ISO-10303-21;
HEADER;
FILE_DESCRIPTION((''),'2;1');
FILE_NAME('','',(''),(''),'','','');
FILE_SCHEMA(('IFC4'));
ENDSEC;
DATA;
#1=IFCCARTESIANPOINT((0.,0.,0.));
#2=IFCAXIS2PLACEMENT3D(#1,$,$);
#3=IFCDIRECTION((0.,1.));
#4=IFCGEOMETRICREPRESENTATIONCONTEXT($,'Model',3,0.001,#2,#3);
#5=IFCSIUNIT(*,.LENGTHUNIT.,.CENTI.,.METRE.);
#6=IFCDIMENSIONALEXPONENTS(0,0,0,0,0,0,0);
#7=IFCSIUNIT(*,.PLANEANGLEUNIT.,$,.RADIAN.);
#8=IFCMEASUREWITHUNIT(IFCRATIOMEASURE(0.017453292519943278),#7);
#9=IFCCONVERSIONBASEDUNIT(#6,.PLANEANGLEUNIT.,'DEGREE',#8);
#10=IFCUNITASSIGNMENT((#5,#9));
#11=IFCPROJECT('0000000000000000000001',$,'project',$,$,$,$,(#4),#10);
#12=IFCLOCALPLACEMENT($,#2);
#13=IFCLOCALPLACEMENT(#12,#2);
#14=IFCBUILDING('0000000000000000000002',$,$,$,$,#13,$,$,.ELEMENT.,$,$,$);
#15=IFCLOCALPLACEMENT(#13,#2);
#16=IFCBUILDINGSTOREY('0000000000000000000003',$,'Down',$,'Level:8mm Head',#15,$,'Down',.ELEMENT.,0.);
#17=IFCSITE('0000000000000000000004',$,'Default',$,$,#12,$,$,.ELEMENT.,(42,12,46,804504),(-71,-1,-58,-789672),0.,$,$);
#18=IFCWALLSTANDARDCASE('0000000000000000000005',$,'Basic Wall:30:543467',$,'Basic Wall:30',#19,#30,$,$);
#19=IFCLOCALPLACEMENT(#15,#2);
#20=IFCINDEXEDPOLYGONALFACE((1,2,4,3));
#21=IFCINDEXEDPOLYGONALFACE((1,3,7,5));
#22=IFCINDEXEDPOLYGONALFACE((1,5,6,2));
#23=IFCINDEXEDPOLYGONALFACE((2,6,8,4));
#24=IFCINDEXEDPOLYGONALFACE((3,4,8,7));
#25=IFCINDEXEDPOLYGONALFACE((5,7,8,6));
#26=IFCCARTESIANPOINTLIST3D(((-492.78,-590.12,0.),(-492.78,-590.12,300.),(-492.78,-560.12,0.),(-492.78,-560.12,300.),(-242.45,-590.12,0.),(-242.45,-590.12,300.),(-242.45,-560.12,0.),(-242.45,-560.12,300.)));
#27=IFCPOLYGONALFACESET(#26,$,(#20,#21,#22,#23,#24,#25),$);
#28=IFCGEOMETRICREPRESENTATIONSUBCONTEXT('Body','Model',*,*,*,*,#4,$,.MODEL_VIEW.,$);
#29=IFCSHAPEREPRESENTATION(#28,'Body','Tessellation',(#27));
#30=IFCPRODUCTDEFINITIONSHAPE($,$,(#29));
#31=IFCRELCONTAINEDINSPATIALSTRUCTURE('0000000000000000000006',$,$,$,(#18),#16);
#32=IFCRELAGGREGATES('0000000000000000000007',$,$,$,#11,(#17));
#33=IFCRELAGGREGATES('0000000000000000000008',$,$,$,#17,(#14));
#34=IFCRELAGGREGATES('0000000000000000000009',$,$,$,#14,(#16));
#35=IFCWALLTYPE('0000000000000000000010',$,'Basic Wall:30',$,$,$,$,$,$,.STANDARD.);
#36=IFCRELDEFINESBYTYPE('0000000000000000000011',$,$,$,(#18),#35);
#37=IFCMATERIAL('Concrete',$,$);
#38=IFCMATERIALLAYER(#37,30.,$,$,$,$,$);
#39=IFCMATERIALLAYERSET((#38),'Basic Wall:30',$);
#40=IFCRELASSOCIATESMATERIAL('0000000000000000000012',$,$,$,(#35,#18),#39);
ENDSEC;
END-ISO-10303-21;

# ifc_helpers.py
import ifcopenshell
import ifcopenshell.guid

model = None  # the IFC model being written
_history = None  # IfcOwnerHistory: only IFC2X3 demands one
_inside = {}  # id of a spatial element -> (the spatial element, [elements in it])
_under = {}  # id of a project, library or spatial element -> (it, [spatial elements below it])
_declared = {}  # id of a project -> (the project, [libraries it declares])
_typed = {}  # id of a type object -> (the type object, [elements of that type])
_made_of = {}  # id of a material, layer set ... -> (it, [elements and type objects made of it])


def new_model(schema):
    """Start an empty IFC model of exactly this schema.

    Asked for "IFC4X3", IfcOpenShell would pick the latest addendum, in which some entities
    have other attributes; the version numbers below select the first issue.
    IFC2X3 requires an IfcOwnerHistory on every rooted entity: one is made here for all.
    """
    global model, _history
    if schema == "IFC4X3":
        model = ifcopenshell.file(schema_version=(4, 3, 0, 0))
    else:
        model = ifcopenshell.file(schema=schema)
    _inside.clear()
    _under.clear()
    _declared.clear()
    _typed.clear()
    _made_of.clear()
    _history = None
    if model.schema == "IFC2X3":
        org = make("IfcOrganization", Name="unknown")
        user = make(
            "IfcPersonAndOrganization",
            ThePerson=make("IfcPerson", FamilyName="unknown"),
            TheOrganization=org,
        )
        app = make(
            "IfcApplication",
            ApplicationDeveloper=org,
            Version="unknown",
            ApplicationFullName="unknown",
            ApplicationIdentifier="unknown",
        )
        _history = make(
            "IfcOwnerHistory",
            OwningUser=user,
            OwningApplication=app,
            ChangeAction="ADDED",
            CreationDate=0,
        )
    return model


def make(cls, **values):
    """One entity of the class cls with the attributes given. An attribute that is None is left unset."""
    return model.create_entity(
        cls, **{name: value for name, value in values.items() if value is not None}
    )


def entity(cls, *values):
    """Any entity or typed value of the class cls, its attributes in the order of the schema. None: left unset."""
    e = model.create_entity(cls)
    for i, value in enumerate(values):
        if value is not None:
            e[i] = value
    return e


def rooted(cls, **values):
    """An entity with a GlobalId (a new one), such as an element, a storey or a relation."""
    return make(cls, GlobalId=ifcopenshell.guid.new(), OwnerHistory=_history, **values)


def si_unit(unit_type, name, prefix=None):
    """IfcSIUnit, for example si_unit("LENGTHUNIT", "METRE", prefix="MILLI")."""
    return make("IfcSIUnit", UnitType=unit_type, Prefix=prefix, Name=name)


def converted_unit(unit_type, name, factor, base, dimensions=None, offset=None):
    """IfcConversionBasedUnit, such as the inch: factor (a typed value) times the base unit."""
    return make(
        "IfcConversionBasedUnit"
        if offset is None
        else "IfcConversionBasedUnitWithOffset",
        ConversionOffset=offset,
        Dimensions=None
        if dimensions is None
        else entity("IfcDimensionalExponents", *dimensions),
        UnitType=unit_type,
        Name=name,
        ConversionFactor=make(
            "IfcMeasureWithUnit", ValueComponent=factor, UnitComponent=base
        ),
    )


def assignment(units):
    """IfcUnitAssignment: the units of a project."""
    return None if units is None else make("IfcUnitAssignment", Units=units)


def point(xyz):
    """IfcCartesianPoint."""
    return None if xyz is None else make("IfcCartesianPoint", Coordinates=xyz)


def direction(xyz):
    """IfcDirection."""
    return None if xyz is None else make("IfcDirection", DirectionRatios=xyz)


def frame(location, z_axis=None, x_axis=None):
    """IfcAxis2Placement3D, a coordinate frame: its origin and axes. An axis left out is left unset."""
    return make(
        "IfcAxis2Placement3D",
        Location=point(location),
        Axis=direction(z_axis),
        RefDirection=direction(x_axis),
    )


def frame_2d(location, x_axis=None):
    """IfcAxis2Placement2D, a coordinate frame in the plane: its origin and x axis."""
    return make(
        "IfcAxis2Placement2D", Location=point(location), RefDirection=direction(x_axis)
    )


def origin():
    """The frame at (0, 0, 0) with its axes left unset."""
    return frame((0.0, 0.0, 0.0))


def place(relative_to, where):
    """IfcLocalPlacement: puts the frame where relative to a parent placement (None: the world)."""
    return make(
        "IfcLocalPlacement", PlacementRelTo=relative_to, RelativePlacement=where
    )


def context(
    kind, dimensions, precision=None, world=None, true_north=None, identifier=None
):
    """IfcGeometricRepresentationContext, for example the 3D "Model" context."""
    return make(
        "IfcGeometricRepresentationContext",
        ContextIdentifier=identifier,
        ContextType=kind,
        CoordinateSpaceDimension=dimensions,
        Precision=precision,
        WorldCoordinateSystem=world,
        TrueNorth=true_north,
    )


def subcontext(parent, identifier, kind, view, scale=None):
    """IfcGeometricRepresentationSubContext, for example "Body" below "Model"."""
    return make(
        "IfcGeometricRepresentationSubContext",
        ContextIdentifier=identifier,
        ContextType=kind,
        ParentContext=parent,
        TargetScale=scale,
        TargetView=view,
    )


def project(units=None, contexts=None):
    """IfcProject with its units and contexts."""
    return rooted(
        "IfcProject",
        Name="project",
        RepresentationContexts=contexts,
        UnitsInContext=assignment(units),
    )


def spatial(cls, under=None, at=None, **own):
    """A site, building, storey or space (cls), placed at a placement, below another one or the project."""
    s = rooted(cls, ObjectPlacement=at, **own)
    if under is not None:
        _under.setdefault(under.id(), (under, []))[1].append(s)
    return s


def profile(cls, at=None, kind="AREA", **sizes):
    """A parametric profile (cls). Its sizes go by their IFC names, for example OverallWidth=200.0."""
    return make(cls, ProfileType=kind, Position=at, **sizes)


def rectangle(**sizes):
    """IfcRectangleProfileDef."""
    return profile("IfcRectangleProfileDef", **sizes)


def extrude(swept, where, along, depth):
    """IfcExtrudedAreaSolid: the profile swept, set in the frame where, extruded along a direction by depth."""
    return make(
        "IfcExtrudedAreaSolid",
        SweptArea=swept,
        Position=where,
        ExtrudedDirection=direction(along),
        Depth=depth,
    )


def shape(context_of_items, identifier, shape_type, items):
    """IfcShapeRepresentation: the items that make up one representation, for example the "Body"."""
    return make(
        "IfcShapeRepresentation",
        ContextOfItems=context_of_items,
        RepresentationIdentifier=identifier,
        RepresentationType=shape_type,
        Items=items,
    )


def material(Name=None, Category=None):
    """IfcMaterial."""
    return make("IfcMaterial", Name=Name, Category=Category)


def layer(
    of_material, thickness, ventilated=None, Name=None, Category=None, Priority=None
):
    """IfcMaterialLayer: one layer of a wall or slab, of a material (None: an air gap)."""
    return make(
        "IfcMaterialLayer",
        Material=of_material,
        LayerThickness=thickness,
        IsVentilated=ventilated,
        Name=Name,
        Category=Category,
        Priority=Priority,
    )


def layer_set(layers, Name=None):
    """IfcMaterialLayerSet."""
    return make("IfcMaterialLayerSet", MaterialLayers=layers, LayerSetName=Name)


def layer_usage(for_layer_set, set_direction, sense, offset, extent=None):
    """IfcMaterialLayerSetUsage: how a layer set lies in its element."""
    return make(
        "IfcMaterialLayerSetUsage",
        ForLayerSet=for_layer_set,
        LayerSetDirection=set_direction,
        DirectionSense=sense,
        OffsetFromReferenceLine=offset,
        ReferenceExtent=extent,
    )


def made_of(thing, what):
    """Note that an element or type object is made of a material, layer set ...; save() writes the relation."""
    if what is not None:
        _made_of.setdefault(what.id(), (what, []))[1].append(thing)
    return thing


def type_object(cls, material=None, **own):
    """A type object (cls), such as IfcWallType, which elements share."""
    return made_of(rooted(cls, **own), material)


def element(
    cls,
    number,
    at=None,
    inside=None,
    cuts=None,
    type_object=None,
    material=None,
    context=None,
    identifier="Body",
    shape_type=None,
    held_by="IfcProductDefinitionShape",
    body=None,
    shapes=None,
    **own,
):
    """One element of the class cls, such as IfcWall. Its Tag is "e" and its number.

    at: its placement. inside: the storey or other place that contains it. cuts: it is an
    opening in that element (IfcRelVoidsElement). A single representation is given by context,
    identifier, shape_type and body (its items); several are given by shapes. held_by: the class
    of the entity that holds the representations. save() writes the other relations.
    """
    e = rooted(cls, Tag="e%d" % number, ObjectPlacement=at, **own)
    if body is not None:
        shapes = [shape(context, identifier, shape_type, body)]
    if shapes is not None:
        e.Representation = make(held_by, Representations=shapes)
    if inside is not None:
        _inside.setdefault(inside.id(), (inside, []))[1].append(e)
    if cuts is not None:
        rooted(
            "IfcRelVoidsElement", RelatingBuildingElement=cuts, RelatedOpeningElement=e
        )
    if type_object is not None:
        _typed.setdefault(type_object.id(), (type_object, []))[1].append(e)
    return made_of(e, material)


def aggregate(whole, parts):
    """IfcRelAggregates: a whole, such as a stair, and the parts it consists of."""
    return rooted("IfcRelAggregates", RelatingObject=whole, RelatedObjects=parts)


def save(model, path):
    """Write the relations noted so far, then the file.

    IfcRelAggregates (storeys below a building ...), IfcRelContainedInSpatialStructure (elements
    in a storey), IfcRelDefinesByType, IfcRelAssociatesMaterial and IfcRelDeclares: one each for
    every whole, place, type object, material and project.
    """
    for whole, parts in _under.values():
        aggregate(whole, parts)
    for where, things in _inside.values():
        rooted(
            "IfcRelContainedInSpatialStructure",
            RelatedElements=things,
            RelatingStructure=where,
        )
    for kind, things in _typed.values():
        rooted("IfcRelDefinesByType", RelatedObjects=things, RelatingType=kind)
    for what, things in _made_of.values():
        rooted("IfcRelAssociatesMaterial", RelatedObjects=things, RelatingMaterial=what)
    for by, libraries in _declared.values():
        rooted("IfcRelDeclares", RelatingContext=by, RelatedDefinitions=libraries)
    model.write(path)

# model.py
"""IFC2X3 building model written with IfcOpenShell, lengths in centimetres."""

from ifc_helpers import new_model, entity, si_unit, converted_unit, direction, frame, frame_2d, origin, place, context, subcontext, project, spatial, rectangle, extrude, material, layer, layer_set, layer_usage, type_object, element, save


model = new_model("IFC2X3")

# Units and contexts
model_context = context("Model", 3, precision=0.001, world=origin(), true_north=direction((0.0, 1.0)))
body_context = subcontext(model_context, "Body", "Model", "MODEL_VIEW")
ifc_project = project(units=[si_unit("LENGTHUNIT", "METRE", prefix="CENTI"), converted_unit("PLANEANGLEUNIT", "DEGREE", entity("IfcRatioMeasure", 0.017453292519943278), si_unit("PLANEANGLEUNIT", "RADIAN"), dimensions=[0, 0, 0, 0, 0, 0, 0])], contexts=[model_context])

# Site, building, storey
site_placement = place(None, origin())
site = spatial("IfcSite", under=ifc_project, at=site_placement, Name="Default", CompositionType="ELEMENT", RefLatitude=(42, 12, 46, 804504), RefLongitude=(-71, -1, -58, -789672), RefElevation=0.0)
building_placement = place(site_placement, origin())
building = spatial("IfcBuilding", under=site, at=building_placement, CompositionType="ELEMENT")
storey_placement = place(building_placement, origin())
storey = spatial("IfcBuildingStorey", under=building, at=storey_placement, Name="Down", ObjectType="Level:8mm Head", LongName="Down", CompositionType="ELEMENT", Elevation=0.0)

# Shared definitions
ifc_material = material(Name="Concrete")

# Wall
ifc_layer_1 = layer(ifc_material, 30.0)
ifc_layer_set_1 = layer_set([ifc_layer_1], Name="Basic Wall:30")
ifc_layer_usage_1 = layer_usage(ifc_layer_set_1, "AXIS2", "POSITIVE", -15.0)
wall_type_1 = type_object("IfcWallType", Name="Basic Wall:30", PredefinedType="STANDARD", material=ifc_layer_set_1)
wall_1_placement = place(storey_placement, frame((-492.78, -575.12, 0.0)))
element("IfcWallStandardCase", 1, at=wall_1_placement, inside=storey, type_object=wall_type_1, material=ifc_layer_usage_1, Name="Basic Wall:30:543467", ObjectType="Basic Wall:30", context=body_context, shape_type="SweptSolid", body=[
    extrude(rectangle(XDim=250.33, YDim=30.0, at=frame_2d((125.17, 0.0), x_axis=(-1.0, 0.0))), origin(), (0.0, 0.0, 1.0), 300.0),
])

save(model, "model.ifc")
